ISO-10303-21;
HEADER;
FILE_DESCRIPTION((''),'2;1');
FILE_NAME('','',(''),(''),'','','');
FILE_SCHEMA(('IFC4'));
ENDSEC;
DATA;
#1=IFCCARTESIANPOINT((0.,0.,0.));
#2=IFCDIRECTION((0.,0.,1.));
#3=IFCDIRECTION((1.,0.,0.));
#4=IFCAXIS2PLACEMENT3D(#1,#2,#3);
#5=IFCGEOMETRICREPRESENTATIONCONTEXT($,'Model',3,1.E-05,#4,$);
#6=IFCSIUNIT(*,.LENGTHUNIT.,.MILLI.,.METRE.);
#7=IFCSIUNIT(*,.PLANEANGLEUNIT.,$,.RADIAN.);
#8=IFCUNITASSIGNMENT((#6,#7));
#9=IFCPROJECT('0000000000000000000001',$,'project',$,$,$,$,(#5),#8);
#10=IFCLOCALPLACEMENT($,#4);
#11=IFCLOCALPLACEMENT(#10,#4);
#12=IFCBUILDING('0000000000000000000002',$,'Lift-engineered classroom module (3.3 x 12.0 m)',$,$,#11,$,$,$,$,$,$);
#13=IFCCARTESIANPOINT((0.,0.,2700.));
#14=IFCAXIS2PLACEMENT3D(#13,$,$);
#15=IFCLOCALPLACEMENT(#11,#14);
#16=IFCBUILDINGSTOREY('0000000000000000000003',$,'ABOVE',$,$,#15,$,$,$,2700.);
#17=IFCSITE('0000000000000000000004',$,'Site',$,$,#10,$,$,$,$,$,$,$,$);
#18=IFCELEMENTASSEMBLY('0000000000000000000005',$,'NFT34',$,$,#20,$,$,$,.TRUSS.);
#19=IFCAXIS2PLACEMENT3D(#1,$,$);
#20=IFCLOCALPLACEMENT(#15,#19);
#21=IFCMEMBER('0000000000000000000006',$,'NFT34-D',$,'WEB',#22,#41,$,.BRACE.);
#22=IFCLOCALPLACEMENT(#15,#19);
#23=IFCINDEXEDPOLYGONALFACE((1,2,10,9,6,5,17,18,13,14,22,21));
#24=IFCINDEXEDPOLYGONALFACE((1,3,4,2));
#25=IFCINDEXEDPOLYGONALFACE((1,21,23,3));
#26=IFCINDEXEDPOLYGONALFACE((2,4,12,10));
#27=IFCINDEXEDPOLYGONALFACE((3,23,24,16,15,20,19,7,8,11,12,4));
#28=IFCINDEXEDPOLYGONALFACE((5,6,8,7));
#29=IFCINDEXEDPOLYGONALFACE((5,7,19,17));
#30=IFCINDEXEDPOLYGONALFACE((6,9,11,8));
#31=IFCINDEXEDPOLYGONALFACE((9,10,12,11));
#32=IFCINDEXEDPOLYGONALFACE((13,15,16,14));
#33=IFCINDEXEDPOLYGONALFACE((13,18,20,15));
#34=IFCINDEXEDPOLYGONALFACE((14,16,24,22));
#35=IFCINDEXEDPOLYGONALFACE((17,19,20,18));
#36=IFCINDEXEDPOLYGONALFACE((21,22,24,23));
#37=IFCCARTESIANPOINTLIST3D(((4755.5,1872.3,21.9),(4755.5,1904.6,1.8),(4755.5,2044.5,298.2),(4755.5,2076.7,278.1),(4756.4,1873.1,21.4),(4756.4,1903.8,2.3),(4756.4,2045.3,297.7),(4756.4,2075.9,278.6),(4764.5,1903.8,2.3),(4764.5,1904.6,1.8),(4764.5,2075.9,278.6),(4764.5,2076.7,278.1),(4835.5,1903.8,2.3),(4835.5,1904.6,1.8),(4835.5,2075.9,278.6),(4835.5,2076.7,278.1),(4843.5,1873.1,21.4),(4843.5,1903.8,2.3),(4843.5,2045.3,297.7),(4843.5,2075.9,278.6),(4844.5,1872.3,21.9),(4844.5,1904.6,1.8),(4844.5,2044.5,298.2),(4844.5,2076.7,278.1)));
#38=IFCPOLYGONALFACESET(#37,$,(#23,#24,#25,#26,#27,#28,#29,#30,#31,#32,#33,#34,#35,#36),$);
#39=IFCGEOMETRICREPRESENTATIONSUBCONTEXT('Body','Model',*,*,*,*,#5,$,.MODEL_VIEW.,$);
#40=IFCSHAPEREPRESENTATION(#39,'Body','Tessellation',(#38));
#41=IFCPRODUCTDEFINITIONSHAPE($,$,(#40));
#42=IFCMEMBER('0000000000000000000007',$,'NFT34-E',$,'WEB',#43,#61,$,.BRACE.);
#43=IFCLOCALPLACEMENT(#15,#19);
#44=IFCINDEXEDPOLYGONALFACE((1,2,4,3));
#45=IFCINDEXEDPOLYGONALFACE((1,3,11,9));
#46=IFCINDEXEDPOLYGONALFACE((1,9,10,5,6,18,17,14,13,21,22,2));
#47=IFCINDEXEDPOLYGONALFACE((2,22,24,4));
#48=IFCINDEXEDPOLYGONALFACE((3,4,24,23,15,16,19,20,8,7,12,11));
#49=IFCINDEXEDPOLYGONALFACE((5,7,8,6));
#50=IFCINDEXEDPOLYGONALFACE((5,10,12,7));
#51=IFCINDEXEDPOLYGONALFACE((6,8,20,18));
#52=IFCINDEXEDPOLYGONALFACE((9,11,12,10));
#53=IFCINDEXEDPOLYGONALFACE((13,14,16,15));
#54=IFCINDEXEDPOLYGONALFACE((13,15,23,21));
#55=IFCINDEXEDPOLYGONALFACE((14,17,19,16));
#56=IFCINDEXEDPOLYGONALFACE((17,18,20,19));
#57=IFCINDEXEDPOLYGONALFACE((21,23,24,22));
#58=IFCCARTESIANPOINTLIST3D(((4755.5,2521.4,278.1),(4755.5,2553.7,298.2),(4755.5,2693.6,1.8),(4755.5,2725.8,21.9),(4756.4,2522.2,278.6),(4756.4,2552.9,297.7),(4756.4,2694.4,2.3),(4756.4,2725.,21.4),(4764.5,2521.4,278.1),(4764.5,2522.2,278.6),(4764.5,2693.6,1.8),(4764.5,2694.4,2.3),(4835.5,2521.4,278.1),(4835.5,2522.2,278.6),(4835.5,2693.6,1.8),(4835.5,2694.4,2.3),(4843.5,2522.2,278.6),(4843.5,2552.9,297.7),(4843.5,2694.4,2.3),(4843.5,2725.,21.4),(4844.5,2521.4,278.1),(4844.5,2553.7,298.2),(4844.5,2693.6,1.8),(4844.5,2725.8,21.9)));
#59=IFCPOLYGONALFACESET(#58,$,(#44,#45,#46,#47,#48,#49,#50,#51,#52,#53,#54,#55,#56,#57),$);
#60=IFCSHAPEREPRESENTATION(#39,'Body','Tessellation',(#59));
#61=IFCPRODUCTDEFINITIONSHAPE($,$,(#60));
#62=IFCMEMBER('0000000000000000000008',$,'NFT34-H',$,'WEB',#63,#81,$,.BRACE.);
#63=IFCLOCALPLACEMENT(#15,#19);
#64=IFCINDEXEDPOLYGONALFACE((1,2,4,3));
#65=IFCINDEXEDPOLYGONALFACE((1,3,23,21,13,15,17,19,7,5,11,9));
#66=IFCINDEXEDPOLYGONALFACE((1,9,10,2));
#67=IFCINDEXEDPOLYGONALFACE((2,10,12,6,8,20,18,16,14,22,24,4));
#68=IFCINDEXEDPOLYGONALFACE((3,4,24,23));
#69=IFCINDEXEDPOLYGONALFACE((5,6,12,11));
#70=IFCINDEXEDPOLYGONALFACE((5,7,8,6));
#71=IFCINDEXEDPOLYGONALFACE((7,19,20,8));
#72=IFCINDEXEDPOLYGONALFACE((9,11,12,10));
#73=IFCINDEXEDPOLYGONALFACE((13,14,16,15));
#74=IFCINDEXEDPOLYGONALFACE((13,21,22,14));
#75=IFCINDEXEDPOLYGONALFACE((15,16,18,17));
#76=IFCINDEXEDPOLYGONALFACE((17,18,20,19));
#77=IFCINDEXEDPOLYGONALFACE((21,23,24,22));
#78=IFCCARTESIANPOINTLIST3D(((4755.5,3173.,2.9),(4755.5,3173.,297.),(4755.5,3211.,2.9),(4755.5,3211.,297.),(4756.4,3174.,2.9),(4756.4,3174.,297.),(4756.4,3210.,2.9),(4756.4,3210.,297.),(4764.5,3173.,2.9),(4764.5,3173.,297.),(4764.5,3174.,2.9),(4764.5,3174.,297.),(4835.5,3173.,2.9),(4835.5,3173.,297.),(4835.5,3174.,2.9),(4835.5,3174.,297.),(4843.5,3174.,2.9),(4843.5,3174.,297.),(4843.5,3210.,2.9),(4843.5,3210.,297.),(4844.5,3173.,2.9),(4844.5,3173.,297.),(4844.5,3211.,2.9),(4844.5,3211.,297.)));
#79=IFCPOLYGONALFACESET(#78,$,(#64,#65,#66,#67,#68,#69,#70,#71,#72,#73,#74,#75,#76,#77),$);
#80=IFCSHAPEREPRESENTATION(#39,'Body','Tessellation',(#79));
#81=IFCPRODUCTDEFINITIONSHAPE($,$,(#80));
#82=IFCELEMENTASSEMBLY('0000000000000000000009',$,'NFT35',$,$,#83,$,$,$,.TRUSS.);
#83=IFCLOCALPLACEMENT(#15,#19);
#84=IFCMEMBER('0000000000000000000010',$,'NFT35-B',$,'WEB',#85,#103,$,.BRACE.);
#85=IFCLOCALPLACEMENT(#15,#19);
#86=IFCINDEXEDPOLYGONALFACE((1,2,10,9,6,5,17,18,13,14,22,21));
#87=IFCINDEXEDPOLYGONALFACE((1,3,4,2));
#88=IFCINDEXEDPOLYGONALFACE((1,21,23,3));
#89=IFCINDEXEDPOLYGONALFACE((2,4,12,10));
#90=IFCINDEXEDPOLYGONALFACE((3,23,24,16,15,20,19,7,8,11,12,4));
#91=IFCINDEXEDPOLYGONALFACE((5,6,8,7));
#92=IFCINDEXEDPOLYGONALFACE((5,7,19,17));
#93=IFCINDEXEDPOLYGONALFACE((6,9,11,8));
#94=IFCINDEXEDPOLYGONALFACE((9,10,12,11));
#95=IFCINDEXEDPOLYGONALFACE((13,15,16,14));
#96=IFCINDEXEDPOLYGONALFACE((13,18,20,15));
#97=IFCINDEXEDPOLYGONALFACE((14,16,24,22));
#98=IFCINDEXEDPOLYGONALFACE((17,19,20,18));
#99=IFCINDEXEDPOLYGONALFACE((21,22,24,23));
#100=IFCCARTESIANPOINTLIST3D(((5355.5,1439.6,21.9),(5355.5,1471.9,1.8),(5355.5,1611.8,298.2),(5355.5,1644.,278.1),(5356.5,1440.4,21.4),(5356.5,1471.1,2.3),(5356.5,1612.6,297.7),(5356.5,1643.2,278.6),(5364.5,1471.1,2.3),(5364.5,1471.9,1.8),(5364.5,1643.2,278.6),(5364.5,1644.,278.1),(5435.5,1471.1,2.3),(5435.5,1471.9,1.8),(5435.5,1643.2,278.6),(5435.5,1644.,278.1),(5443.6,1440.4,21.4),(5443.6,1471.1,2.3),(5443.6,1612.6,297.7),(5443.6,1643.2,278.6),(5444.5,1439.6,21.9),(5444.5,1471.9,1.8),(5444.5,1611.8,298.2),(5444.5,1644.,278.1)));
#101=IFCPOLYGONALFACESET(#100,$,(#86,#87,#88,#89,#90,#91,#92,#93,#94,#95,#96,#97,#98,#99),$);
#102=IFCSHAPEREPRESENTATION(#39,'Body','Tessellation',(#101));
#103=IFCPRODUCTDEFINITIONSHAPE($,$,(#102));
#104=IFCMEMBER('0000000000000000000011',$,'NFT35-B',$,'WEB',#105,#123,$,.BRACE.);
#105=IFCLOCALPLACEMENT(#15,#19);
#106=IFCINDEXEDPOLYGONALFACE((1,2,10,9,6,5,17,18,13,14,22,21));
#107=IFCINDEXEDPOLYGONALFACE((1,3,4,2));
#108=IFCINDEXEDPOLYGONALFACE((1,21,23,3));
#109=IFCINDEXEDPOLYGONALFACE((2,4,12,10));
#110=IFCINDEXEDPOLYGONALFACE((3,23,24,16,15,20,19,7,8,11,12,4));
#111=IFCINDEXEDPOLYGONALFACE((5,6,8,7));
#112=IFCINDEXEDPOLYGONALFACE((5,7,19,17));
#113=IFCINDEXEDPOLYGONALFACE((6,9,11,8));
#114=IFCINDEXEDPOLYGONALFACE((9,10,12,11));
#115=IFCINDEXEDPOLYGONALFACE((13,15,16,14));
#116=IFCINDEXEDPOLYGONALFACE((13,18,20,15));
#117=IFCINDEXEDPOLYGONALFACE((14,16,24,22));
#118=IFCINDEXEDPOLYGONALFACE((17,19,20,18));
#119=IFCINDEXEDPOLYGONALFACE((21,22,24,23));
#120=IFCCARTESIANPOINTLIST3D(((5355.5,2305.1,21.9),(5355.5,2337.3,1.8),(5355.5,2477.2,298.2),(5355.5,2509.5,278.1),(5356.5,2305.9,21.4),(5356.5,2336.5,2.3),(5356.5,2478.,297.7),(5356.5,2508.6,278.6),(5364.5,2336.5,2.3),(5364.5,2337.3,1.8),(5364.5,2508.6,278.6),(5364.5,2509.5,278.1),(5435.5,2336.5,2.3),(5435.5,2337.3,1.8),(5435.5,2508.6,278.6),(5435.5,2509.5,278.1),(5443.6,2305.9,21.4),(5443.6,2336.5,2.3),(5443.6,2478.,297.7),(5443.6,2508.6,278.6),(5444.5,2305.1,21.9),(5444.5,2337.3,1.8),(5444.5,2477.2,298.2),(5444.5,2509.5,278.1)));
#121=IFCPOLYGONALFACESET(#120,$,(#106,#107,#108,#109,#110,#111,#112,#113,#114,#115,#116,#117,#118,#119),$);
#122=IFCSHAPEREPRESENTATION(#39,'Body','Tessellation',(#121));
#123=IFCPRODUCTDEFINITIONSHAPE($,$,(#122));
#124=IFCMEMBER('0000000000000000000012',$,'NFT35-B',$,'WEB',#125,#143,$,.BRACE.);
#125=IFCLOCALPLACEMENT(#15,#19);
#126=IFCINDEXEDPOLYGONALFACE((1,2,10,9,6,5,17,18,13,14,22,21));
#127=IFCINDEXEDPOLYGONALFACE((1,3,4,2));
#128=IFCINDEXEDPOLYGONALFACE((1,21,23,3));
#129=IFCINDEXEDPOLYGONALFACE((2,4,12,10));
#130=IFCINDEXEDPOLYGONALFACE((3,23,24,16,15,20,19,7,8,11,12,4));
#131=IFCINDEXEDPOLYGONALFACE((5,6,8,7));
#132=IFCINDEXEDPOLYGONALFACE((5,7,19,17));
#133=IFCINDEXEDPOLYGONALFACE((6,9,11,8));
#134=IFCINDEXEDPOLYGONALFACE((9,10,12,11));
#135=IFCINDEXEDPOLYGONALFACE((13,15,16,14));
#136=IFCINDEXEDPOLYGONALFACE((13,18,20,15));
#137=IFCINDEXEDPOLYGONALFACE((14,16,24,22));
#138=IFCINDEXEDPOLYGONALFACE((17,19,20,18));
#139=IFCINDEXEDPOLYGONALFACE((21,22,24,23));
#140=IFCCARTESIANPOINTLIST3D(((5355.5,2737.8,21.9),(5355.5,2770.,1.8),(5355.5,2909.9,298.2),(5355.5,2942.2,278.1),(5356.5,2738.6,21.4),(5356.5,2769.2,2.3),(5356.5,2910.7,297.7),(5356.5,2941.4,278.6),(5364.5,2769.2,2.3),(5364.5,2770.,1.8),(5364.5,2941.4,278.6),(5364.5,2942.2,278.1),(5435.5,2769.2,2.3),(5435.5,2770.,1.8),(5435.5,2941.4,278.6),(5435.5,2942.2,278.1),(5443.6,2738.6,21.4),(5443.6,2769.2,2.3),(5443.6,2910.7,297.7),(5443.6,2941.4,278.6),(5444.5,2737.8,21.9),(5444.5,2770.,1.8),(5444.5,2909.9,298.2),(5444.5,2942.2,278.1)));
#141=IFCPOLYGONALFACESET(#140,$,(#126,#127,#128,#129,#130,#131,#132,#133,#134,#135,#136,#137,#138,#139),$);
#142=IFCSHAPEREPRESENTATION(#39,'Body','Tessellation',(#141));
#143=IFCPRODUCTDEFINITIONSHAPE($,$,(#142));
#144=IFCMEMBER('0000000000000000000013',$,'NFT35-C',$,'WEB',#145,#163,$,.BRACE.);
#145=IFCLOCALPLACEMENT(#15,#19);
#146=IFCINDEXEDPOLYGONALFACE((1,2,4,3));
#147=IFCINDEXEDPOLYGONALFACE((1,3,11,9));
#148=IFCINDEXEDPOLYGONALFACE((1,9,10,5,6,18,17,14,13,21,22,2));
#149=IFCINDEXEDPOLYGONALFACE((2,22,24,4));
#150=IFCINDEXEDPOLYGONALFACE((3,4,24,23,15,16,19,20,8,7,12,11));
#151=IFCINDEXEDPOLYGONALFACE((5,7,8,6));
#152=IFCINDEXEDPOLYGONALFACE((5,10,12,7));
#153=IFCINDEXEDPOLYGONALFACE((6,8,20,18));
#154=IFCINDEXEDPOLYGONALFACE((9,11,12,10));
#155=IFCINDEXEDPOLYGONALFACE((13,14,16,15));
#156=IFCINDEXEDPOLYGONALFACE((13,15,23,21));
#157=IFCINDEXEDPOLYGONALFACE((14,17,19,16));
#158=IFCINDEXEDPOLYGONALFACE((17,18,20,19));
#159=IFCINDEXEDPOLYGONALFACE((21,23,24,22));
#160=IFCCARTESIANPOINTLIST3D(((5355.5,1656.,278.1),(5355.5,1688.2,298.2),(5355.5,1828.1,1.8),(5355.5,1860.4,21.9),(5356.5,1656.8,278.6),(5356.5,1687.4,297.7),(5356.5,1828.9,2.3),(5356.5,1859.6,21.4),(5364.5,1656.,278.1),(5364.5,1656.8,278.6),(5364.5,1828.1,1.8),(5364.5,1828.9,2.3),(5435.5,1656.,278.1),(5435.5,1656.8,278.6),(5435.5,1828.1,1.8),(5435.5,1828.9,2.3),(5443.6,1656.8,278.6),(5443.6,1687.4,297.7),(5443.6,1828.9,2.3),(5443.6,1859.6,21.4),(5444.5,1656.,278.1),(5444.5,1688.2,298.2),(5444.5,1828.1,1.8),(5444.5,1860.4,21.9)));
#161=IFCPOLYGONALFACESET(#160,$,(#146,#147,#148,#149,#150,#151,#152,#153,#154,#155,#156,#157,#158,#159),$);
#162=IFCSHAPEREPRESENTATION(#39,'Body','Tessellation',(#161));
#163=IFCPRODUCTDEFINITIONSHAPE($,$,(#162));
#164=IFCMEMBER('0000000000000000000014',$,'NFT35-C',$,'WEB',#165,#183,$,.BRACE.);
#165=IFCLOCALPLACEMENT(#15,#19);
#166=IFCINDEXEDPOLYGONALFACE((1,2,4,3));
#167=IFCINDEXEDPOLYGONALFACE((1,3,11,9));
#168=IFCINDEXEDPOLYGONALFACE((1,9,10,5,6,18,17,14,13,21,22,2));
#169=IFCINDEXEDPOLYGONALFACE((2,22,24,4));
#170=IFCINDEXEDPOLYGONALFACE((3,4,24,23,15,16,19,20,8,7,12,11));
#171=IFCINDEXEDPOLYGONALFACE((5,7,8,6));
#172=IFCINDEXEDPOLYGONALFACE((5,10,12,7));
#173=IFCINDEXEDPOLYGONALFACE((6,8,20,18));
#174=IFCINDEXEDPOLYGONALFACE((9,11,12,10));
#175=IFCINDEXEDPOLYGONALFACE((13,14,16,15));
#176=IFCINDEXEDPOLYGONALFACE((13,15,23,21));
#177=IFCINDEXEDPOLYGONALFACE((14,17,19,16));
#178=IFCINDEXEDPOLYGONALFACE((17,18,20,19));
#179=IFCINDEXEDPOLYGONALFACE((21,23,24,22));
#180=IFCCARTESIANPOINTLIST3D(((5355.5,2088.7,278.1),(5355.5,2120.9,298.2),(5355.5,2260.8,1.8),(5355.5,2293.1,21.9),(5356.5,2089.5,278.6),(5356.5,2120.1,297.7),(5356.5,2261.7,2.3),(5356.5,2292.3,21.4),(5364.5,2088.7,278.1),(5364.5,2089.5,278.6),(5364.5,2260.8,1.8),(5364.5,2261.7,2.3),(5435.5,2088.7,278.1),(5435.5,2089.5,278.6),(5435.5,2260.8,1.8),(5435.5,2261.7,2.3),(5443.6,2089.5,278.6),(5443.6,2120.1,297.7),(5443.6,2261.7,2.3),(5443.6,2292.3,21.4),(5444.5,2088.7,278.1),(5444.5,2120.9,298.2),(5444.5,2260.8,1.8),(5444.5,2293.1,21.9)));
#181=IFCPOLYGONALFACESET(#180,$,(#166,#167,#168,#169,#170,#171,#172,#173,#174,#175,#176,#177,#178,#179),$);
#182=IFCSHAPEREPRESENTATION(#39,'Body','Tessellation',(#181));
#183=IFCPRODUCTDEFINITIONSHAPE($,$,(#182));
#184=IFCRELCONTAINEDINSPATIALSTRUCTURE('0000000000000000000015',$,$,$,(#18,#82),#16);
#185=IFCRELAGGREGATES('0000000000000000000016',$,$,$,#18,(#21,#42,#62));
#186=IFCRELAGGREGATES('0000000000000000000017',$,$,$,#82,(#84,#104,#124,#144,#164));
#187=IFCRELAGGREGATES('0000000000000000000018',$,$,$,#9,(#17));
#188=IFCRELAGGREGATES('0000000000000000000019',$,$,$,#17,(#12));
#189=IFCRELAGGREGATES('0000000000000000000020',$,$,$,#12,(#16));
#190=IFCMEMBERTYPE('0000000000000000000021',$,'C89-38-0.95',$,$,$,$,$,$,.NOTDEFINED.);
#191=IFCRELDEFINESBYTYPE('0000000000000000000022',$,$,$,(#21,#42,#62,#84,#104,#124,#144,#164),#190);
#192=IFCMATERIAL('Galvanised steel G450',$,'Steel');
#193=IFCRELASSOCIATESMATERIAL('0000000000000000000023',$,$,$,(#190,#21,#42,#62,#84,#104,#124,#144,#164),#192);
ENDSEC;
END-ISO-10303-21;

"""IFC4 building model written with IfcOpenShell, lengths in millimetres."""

from ifc_helpers import new_model, si_unit, frame, origin, origin_with_axes, origin_2d, place, context, subcontext, project, spatial, c_section, extrude, material, material_profile, profile_set, profile_usage, type_object, element, aggregate, save


model = new_model("IFC4")

# Units and contexts
model_context = context("Model", 3, precision=1e-05, world=origin_with_axes())
body_context = subcontext(model_context, "Body", "Model", "MODEL_VIEW")
ifc_project = project(units=[si_unit("LENGTHUNIT", "METRE", prefix="MILLI"), si_unit("PLANEANGLEUNIT", "RADIAN")], contexts=[model_context])

# Site, building, storey
site_placement = place(None, origin_with_axes())
site = spatial("IfcSite", under=ifc_project, at=site_placement, Name="Site")
building_placement = place(site_placement, origin_with_axes())
building = spatial("IfcBuilding", under=site, at=building_placement, Name="Lift-engineered classroom module (3.3 x 12.0 m)")
storey_placement = place(building_placement, frame((0.0, 0.0, 2700.0)))
storey = spatial("IfcBuildingStorey", under=building, at=storey_placement, Name="ABOVE", Elevation=2700.0)

# Element assemblies, members
ifc_material = material(Name="Galvanised steel G450", Category="Steel")
ifc_material_profile_1 = material_profile(ifc_material, c_section(Depth=89.0, Width=38.0, WallThickness=0.9, Girth=9.0, at=origin_2d()), Name="C89-38-0.95")
ifc_profile_set_1 = profile_set([ifc_material_profile_1], Name="C89-38-0.95")
ifc_profile_usage_1 = profile_usage(ifc_profile_set_1)
member_type_1 = type_object("IfcMemberType", Name="C89-38-0.95", PredefinedType="NOTDEFINED", material=ifc_profile_set_1)
assembly_1_placement = place(storey_placement, frame((4800.0, 89.0, 0.0)))
assembly_1 = element("IfcElementAssembly", 1, at=assembly_1_placement, inside=storey, Name="NFT34", PredefinedType="TRUSS")
member_1_placement = place(assembly_1_placement, frame((0.0, 1799.5, 11.8), z_axis=(0.0, 0.528775, 0.848762), x_axis=(0.0, 0.848762, -0.528775)))
member_1 = element("IfcMember", 2, at=member_1_placement, type_object=member_type_1, material=ifc_profile_usage_1, Name="NFT34-D", ObjectType="WEB", PredefinedType="BRACE", context=body_context, shape_type="SweptSolid", body=[
    extrude(c_section(Depth=89.0, Width=38.0, WallThickness=0.9, Girth=9.0, at=origin_2d()), origin(), (0.0, 0.0, 1.0), 325.6),
])
member_2_placement = place(assembly_1_placement, frame((0.0, 2620.7, 11.8), z_axis=(0.0, -0.528775, 0.848762), x_axis=(0.0, -0.848762, -0.528775)))
member_2 = element("IfcMember", 3, at=member_2_placement, type_object=member_type_1, material=ifc_profile_usage_1, Name="NFT34-E", ObjectType="WEB", PredefinedType="BRACE", context=body_context, shape_type="SweptSolid", body=[
    extrude(c_section(Depth=89.0, Width=38.0, WallThickness=0.9, Girth=9.0, at=origin_2d()), origin(), (0.0, 0.0, 1.0), 325.6),
])
member_3_placement = place(assembly_1_placement, frame((0.0, 3103.0, 2.9), z_axis=(0.0, 0.0, 1.0), x_axis=(0.0, -1.0, 0.0)))
member_3 = element("IfcMember", 4, at=member_3_placement, type_object=member_type_1, material=ifc_profile_usage_1, Name="NFT34-H", ObjectType="WEB", PredefinedType="BRACE", context=body_context, shape_type="SweptSolid", body=[
    extrude(c_section(Depth=89.0, Width=38.0, WallThickness=0.9, Girth=9.0, at=origin_2d()), origin(), (0.0, 0.0, 1.0), 294.1),
])
aggregate(assembly_1, [member_1, member_2, member_3])
assembly_2_placement = place(storey_placement, frame((5400.0, 89.0, 0.0)))
assembly_2 = element("IfcElementAssembly", 5, at=assembly_2_placement, inside=storey, Name="NFT35", PredefinedType="TRUSS")
member_4_placement = place(assembly_2_placement, frame((0.0, 1366.7, 11.8), z_axis=(0.0, 0.528797, 0.848748), x_axis=(0.0, 0.848748, -0.528797)))
member_4 = element("IfcMember", 6, at=member_4_placement, type_object=member_type_1, material=ifc_profile_usage_1, Name="NFT35-B", ObjectType="WEB", PredefinedType="BRACE", context=body_context, shape_type="SweptSolid", body=[
    extrude(c_section(Depth=89.0, Width=38.0, WallThickness=0.9, Girth=9.0, at=origin_2d()), origin(), (0.0, 0.0, 1.0), 325.6),
])
member_5_placement = place(assembly_2_placement, frame((0.0, 2232.2, 11.8), z_axis=(0.0, 0.528797, 0.848748), x_axis=(0.0, 0.848748, -0.528797)))
member_5 = element("IfcMember", 7, at=member_5_placement, type_object=member_type_1, material=ifc_profile_usage_1, Name="NFT35-B", ObjectType="WEB", PredefinedType="BRACE", context=body_context, shape_type="SweptSolid", body=[
    extrude(c_section(Depth=89.0, Width=38.0, WallThickness=0.9, Girth=9.0, at=origin_2d()), origin(), (0.0, 0.0, 1.0), 325.6),
])
member_6_placement = place(assembly_2_placement, frame((0.0, 2664.9, 11.8), z_axis=(0.0, 0.528797, 0.848748), x_axis=(0.0, 0.848748, -0.528797)))
member_6 = element("IfcMember", 8, at=member_6_placement, type_object=member_type_1, material=ifc_profile_usage_1, Name="NFT35-B", ObjectType="WEB", PredefinedType="BRACE", context=body_context, shape_type="SweptSolid", body=[
    extrude(c_section(Depth=89.0, Width=38.0, WallThickness=0.9, Girth=9.0, at=origin_2d()), origin(), (0.0, 0.0, 1.0), 325.6),
])
member_7_placement = place(assembly_2_placement, frame((0.0, 1755.3, 11.8), z_axis=(0.0, -0.528797, 0.848748), x_axis=(0.0, -0.848748, -0.528797)))
member_7 = element("IfcMember", 9, at=member_7_placement, type_object=member_type_1, material=ifc_profile_usage_1, Name="NFT35-C", ObjectType="WEB", PredefinedType="BRACE", context=body_context, shape_type="SweptSolid", body=[
    extrude(c_section(Depth=89.0, Width=38.0, WallThickness=0.9, Girth=9.0, at=origin_2d()), origin(), (0.0, 0.0, 1.0), 325.6),
])
member_8_placement = place(assembly_2_placement, frame((0.0, 2188.0, 11.8), z_axis=(0.0, -0.528797, 0.848748), x_axis=(0.0, -0.848748, -0.528797)))
member_8 = element("IfcMember", 10, at=member_8_placement, type_object=member_type_1, material=ifc_profile_usage_1, Name="NFT35-C", ObjectType="WEB", PredefinedType="BRACE", context=body_context, shape_type="SweptSolid", body=[
    extrude(c_section(Depth=89.0, Width=38.0, WallThickness=0.9, Girth=9.0, at=origin_2d()), origin(), (0.0, 0.0, 1.0), 325.6),
])
aggregate(assembly_2, [member_4, member_5, member_6, member_7, member_8])

save(model, "model.ifc")
